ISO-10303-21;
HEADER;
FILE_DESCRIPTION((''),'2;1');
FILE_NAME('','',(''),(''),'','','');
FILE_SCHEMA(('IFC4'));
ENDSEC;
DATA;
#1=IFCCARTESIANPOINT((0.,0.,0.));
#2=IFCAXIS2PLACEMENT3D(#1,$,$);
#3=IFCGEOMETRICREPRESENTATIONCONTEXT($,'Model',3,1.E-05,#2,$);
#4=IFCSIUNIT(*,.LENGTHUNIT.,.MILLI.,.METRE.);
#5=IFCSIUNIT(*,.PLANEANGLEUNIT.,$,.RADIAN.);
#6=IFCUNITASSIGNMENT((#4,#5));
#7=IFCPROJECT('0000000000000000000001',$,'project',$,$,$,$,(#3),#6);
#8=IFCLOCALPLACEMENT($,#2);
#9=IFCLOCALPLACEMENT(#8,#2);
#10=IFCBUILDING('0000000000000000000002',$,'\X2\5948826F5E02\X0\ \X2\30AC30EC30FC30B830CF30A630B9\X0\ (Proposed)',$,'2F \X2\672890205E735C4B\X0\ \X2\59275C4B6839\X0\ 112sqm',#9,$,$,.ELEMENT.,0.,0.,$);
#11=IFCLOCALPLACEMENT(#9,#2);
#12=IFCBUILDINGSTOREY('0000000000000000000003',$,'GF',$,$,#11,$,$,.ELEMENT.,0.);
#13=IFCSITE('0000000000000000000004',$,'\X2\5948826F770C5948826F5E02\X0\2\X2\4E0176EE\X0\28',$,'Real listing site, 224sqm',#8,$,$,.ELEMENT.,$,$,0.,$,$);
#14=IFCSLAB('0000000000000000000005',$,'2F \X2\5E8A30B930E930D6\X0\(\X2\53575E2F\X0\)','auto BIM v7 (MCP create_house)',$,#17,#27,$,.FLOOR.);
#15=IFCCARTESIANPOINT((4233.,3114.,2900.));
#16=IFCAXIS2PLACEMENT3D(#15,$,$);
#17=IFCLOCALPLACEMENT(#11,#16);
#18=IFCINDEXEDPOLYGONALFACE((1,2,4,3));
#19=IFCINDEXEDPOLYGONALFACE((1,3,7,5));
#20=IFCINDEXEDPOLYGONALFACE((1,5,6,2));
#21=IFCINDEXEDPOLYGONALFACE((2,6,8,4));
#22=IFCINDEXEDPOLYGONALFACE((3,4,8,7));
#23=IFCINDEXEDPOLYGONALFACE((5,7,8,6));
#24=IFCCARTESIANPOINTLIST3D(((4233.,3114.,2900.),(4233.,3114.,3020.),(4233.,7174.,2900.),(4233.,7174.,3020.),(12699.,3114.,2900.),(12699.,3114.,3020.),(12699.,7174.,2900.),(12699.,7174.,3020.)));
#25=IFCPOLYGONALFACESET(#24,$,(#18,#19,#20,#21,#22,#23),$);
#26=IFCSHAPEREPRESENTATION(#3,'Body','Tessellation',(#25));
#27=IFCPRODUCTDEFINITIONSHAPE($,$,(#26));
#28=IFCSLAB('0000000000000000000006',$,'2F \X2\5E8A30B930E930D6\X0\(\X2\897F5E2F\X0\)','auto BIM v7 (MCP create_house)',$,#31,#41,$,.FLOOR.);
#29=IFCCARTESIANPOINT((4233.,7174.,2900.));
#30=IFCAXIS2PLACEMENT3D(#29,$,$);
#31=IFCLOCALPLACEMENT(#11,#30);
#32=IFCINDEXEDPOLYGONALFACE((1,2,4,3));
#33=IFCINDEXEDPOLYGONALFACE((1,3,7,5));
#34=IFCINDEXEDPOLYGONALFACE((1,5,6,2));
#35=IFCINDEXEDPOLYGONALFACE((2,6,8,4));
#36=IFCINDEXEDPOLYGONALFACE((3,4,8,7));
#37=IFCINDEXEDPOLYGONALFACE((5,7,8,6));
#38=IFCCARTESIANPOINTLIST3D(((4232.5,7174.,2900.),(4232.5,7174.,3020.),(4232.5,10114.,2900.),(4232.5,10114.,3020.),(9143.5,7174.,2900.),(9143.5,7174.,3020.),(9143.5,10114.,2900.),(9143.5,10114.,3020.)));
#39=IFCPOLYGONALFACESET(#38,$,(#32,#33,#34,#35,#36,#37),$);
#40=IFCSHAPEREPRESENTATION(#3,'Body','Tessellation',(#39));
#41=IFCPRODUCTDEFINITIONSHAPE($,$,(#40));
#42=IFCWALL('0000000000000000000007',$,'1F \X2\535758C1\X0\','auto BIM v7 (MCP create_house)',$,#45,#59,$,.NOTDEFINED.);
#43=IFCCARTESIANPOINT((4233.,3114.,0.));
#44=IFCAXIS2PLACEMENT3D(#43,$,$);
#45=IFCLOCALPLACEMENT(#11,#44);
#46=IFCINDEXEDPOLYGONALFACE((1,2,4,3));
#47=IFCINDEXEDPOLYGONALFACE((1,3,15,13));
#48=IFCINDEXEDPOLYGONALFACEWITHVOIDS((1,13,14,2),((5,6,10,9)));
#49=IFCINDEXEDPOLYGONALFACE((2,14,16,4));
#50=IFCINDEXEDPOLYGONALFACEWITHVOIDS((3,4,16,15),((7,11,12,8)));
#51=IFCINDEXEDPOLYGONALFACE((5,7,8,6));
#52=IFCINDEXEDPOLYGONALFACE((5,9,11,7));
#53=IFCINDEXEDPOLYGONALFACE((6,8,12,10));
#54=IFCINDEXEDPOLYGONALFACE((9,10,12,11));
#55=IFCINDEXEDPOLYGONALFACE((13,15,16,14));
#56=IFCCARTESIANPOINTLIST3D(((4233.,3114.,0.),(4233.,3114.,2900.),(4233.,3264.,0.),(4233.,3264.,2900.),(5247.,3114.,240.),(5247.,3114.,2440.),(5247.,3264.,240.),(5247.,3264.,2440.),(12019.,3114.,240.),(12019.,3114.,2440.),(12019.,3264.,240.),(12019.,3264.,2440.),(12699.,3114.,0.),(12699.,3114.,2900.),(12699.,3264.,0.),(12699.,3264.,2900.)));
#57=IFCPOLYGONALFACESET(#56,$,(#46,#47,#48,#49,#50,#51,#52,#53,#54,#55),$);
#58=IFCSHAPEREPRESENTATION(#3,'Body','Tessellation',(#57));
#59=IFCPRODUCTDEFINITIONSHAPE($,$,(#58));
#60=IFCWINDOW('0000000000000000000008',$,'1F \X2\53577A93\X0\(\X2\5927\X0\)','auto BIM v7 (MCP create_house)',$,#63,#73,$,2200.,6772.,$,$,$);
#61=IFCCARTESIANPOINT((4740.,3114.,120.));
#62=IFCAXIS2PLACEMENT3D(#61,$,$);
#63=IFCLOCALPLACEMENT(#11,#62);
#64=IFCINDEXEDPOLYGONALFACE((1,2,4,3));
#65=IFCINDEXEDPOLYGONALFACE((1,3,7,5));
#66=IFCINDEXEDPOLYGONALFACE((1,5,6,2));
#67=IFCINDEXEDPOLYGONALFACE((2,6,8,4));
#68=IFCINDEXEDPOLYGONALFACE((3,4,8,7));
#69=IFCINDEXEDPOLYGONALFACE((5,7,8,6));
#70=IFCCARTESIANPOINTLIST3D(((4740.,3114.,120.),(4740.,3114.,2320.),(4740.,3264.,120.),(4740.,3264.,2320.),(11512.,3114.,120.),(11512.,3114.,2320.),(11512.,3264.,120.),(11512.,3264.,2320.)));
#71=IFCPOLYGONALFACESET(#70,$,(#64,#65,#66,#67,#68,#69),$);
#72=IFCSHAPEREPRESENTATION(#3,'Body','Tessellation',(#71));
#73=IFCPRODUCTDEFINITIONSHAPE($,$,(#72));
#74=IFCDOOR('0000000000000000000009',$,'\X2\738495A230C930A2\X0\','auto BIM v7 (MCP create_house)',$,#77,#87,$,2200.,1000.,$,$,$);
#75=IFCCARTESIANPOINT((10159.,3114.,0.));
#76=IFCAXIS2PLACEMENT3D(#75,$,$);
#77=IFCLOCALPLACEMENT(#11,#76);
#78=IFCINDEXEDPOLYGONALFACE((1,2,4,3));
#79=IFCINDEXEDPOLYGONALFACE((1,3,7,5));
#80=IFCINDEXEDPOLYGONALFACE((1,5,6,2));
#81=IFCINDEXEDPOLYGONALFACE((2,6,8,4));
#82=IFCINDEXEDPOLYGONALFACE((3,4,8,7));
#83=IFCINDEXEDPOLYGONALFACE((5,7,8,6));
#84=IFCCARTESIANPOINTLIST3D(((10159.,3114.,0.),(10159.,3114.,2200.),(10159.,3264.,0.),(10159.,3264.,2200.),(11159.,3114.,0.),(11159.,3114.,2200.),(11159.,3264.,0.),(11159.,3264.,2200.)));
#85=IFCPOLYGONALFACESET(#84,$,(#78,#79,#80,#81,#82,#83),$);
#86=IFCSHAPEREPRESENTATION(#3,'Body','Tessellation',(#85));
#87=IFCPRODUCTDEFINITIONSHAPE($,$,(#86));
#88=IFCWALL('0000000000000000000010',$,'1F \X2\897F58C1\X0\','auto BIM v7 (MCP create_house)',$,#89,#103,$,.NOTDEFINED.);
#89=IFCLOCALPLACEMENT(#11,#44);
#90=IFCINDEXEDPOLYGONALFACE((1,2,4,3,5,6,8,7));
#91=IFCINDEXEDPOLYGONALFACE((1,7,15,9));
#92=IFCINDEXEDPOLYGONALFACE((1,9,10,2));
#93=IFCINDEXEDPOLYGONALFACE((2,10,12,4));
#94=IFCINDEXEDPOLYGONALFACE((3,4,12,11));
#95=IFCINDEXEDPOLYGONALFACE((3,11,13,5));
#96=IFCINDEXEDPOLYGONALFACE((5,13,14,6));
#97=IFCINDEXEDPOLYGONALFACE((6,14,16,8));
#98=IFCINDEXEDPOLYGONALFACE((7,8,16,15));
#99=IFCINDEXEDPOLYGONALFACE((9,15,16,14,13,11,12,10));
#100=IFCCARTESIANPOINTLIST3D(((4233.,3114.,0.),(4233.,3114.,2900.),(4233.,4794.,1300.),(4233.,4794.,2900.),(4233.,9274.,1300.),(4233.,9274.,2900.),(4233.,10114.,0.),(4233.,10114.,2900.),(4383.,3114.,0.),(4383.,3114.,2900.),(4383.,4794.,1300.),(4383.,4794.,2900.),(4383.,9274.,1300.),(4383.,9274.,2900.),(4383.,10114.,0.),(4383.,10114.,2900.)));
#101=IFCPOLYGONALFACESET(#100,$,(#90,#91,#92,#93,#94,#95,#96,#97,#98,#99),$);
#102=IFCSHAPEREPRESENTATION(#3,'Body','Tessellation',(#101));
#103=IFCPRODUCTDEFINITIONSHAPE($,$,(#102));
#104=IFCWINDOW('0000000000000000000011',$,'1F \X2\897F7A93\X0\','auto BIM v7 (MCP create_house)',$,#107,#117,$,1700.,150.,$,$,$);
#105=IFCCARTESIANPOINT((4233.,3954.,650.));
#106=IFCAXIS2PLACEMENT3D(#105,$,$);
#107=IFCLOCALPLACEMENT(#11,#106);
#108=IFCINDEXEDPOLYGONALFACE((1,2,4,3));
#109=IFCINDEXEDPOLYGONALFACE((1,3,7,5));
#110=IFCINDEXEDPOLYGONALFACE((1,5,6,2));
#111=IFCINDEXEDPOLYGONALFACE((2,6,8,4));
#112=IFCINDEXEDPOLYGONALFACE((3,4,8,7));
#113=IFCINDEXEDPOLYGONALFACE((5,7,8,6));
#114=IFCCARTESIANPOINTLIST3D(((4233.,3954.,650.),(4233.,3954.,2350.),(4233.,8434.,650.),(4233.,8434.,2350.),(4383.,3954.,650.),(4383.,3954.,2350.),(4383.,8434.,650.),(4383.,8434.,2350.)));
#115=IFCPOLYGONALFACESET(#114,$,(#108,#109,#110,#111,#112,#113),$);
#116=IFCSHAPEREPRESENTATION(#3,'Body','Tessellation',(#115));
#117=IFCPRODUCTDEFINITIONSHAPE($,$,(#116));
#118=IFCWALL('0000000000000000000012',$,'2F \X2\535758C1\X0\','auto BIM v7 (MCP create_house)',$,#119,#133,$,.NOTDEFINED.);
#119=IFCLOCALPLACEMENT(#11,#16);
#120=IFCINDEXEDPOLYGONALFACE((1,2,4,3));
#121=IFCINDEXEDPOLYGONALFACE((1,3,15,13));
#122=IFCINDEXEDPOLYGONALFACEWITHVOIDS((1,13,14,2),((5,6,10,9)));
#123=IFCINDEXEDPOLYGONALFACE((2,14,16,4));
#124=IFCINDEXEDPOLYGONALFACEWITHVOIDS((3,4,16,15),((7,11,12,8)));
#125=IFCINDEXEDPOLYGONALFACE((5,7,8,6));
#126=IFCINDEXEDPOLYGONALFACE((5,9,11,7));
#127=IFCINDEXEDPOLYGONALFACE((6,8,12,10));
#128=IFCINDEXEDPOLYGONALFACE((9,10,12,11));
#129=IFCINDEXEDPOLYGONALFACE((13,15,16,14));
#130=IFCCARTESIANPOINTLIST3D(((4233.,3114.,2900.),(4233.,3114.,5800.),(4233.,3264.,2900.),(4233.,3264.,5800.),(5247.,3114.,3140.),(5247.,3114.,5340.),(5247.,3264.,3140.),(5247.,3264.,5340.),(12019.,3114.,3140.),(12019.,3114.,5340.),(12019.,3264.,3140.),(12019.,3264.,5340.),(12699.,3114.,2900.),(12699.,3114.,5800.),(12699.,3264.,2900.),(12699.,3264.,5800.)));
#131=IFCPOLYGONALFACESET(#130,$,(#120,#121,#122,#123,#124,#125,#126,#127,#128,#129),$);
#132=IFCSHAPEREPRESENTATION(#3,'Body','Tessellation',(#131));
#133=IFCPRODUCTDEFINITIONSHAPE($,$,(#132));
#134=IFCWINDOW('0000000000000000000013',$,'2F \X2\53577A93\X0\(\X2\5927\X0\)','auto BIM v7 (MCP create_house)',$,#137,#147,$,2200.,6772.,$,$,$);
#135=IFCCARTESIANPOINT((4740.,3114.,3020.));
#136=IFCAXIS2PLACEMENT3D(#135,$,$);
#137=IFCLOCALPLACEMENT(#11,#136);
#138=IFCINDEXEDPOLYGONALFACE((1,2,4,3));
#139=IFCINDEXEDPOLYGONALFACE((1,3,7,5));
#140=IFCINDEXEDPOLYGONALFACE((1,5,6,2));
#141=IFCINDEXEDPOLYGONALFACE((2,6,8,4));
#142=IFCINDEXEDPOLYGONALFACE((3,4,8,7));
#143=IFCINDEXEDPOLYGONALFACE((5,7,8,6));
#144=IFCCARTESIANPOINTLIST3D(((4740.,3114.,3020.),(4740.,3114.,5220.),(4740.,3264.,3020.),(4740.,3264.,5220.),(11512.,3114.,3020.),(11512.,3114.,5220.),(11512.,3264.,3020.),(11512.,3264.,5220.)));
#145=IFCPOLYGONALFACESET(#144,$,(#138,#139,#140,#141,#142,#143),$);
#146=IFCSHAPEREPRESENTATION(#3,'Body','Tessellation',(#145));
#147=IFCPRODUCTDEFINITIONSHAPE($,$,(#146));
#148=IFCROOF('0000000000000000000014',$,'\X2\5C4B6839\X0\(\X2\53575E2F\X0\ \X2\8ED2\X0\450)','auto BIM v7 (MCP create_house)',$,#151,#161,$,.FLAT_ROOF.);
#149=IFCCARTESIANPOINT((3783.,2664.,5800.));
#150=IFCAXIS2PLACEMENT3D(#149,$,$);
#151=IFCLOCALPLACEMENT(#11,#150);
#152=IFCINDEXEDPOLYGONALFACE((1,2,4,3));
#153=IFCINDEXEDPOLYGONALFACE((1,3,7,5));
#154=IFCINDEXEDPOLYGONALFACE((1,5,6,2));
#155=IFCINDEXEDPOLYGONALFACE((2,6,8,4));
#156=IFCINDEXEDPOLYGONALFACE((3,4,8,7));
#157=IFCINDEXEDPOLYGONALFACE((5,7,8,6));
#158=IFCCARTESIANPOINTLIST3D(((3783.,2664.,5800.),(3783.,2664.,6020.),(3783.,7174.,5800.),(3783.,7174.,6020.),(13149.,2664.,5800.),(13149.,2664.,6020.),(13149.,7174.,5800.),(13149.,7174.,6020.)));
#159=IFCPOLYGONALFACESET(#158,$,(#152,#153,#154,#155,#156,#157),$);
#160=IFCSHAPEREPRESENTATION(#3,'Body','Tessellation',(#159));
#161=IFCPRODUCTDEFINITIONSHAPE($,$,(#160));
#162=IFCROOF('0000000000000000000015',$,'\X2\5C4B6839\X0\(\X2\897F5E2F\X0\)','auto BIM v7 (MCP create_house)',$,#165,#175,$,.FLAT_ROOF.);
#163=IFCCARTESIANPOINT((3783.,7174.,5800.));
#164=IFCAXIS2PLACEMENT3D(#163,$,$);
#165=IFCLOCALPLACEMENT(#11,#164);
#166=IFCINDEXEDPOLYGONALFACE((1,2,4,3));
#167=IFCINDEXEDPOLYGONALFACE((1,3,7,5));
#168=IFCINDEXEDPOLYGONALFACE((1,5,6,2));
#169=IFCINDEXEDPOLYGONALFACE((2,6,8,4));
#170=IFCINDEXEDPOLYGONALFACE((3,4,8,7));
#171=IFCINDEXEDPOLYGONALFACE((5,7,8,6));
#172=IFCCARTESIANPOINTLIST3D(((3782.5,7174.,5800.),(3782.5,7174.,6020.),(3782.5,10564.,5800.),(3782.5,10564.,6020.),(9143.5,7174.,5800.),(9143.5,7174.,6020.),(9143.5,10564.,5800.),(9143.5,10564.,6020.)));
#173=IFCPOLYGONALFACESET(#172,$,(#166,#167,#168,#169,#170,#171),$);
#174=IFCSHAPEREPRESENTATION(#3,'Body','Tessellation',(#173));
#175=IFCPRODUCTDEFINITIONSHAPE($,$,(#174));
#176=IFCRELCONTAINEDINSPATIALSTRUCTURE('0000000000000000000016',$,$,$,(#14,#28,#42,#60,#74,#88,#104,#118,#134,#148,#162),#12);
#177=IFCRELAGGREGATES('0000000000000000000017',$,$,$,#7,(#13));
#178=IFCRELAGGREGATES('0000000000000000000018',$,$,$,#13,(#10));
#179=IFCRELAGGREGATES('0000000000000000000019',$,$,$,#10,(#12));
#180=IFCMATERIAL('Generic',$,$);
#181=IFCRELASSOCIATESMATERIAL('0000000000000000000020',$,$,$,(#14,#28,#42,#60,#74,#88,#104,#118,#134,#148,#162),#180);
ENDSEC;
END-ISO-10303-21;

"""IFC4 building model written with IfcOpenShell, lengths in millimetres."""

from ifc_helpers import new_model, si_unit, frame, frame_2d, origin, place, context, project, spatial, rectangle, extrude, material, element, fill, save


model = new_model("IFC4")

# Units and contexts
model_context = context("Model", 3, precision=1e-05, world=origin())
ifc_project = project(units=[si_unit("LENGTHUNIT", "METRE", prefix="MILLI"), si_unit("PLANEANGLEUNIT", "RADIAN")], contexts=[model_context])

# Site, building, storey
site_placement = place(None, origin())
site = spatial("IfcSite", under=ifc_project, at=site_placement, Name="奈良県奈良市2丁目28", ObjectType="Real listing site, 224sqm", CompositionType="ELEMENT", RefElevation=0.0)
building_placement = place(site_placement, origin())
building = spatial("IfcBuilding", under=site, at=building_placement, Name="奈良市 ガレージハウス (Proposed)", ObjectType="2F 木造平屋 大屋根 112sqm", CompositionType="ELEMENT", ElevationOfRefHeight=0.0, ElevationOfTerrain=0.0)
storey_placement = place(building_placement, origin())
storey = spatial("IfcBuildingStorey", under=building, at=storey_placement, Name="GF", CompositionType="ELEMENT", Elevation=0.0)

# Slabs
ifc_material = material(Name="Generic")
slab_1_placement = place(storey_placement, frame((4233.0, 3114.0, 2900.0)))
element("IfcSlab", 1, at=slab_1_placement, inside=storey, material=ifc_material, Name="2F 床スラブ(南帯)", Description="auto BIM v7 (MCP create_house)", PredefinedType="FLOOR", context=model_context, shape_type="SweptSolid", body=[
    extrude(rectangle(XDim=8466.0, YDim=4060.0, at=frame_2d((4233.0, 2030.0))), frame((4233.0, 3114.0, 2900.0)), (0.0, 0.0, 1.0), 120.0),
])
slab_2_placement = place(storey_placement, frame((4233.0, 7174.0, 2900.0)))
element("IfcSlab", 2, at=slab_2_placement, inside=storey, material=ifc_material, Name="2F 床スラブ(西帯)", Description="auto BIM v7 (MCP create_house)", PredefinedType="FLOOR", context=model_context, shape_type="SweptSolid", body=[
    extrude(rectangle(XDim=4911.0, YDim=2940.0, at=frame_2d((2455.0, 1470.0))), frame((4233.0, 7174.0, 2900.0)), (0.0, 0.0, 1.0), 120.0),
])

# Wall, openings, window, door
wall_1_placement = place(storey_placement, frame((4233.0, 3114.0, 0.0)))
wall_1 = element("IfcWall", 3, at=wall_1_placement, inside=storey, material=ifc_material, Name="1F 南壁", Description="auto BIM v7 (MCP create_house)", PredefinedType="NOTDEFINED", context=model_context, shape_type="SweptSolid", body=[
    extrude(rectangle(XDim=8466.0, YDim=150.0, at=frame_2d((4233.0, 75.0))), frame((4233.0, 3114.0, 0.0)), (0.0, 0.0, 1.0), 2900.0),
])
opening_1_placement = place(storey_placement, frame((4740.0, 3114.0, 120.0)))
opening_1 = element("IfcOpeningElement", 4, at=opening_1_placement, cuts=wall_1, PredefinedType="NOTDEFINED", context=model_context, shape_type="SweptSolid", body=[
    extrude(rectangle(XDim=6772.0, YDim=150.0, at=frame_2d((3386.0, 75.0))), frame((4740.0, 3114.0, 120.0)), (0.0, 0.0, 1.0), 2200.0),
])
opening_2_placement = place(storey_placement, frame((10159.0, 3114.0, 0.0)))
opening_2 = element("IfcOpeningElement", 5, at=opening_2_placement, cuts=wall_1, PredefinedType="NOTDEFINED", context=model_context, shape_type="SweptSolid", body=[
    extrude(rectangle(XDim=1000.0, YDim=150.0, at=frame_2d((500.0, 75.0))), frame((10159.0, 3114.0, 0.0)), (0.0, 0.0, 1.0), 2200.0),
])
window_1_placement = place(storey_placement, frame((4740.0, 3114.0, 120.0)))
window_1 = element("IfcWindow", 6, at=window_1_placement, inside=storey, material=ifc_material, Name="1F 南窓(大)", Description="auto BIM v7 (MCP create_house)", OverallHeight=2200.0, OverallWidth=6772.0, context=model_context, shape_type="SweptSolid", body=[
    extrude(rectangle(XDim=6772.0, YDim=150.0, at=frame_2d((3386.0, 75.0))), frame((4740.0, 3114.0, 120.0)), (0.0, 0.0, 1.0), 2200.0),
])
fill(opening_1, window_1)
door_placement = place(storey_placement, frame((10159.0, 3114.0, 0.0)))
door = element("IfcDoor", 7, at=door_placement, inside=storey, material=ifc_material, Name="玄関ドア", Description="auto BIM v7 (MCP create_house)", OverallHeight=2200.0, OverallWidth=1000.0, context=model_context, shape_type="SweptSolid", body=[
    extrude(rectangle(XDim=1000.0, YDim=150.0, at=frame_2d((500.0, 75.0))), frame((10159.0, 3114.0, 0.0)), (0.0, 0.0, 1.0), 2200.0),
])
fill(opening_2, door)

# Wall, opening, window
wall_2_placement = place(storey_placement, frame((4233.0, 3114.0, 0.0)))
wall_2 = element("IfcWall", 8, at=wall_2_placement, inside=storey, material=ifc_material, Name="1F 西壁", Description="auto BIM v7 (MCP create_house)", PredefinedType="NOTDEFINED", context=model_context, shape_type="SweptSolid", body=[
    extrude(rectangle(XDim=150.0, YDim=7000.0, at=frame_2d((75.0, 3500.0))), frame((4233.0, 3114.0, 0.0)), (0.0, 0.0, 1.0), 2900.0),
])
opening_3_placement = place(storey_placement, frame((4233.0, 3954.0, 650.0)))
opening_3 = element("IfcOpeningElement", 9, at=opening_3_placement, cuts=wall_2, PredefinedType="NOTDEFINED", context=model_context, shape_type="SweptSolid", body=[
    extrude(rectangle(XDim=150.0, YDim=4480.0, at=frame_2d((75.0, 2240.0))), frame((4233.0, 3954.0, 650.0)), (0.0, 0.0, 1.0), 1700.0),
])
window_2_placement = place(storey_placement, frame((4233.0, 3954.0, 650.0)))
window_2 = element("IfcWindow", 10, at=window_2_placement, inside=storey, material=ifc_material, Name="1F 西窓", Description="auto BIM v7 (MCP create_house)", OverallHeight=1700.0, OverallWidth=150.0, context=model_context, shape_type="SweptSolid", body=[
    extrude(rectangle(XDim=150.0, YDim=4480.0, at=frame_2d((75.0, 2240.0))), frame((4233.0, 3954.0, 650.0)), (0.0, 0.0, 1.0), 1700.0),
])
fill(opening_3, window_2)

# Wall, opening, window
wall_3_placement = place(storey_placement, frame((4233.0, 3114.0, 2900.0)))
wall_3 = element("IfcWall", 11, at=wall_3_placement, inside=storey, material=ifc_material, Name="2F 南壁", Description="auto BIM v7 (MCP create_house)", PredefinedType="NOTDEFINED", context=model_context, shape_type="SweptSolid", body=[
    extrude(rectangle(XDim=8466.0, YDim=150.0, at=frame_2d((4233.0, 75.0))), frame((4233.0, 3114.0, 2900.0)), (0.0, 0.0, 1.0), 2900.0),
])
opening_4_placement = place(storey_placement, frame((4740.0, 3114.0, 3020.0)))
opening_4 = element("IfcOpeningElement", 12, at=opening_4_placement, cuts=wall_3, PredefinedType="NOTDEFINED", context=model_context, shape_type="SweptSolid", body=[
    extrude(rectangle(XDim=6772.0, YDim=150.0, at=frame_2d((3386.0, 75.0))), frame((4740.0, 3114.0, 3020.0)), (0.0, 0.0, 1.0), 2200.0),
])
window_3_placement = place(storey_placement, frame((4740.0, 3114.0, 3020.0)))
window_3 = element("IfcWindow", 13, at=window_3_placement, inside=storey, material=ifc_material, Name="2F 南窓(大)", Description="auto BIM v7 (MCP create_house)", OverallHeight=2200.0, OverallWidth=6772.0, context=model_context, shape_type="SweptSolid", body=[
    extrude(rectangle(XDim=6772.0, YDim=150.0, at=frame_2d((3386.0, 75.0))), frame((4740.0, 3114.0, 3020.0)), (0.0, 0.0, 1.0), 2200.0),
])
fill(opening_4, window_3)

# Roofs
roof_1_placement = place(storey_placement, frame((3783.0, 2664.0, 5800.0)))
element("IfcRoof", 14, at=roof_1_placement, inside=storey, material=ifc_material, Name="屋根(南帯 軒450)", Description="auto BIM v7 (MCP create_house)", PredefinedType="FLAT_ROOF", context=model_context, shape_type="SweptSolid", body=[
    extrude(rectangle(XDim=9366.0, YDim=4510.0, at=frame_2d((4683.0, 2255.0))), frame((3783.0, 2664.0, 5800.0)), (0.0, 0.0, 1.0), 220.0),
])
roof_2_placement = place(storey_placement, frame((3783.0, 7174.0, 5800.0)))
element("IfcRoof", 15, at=roof_2_placement, inside=storey, material=ifc_material, Name="屋根(西帯)", Description="auto BIM v7 (MCP create_house)", PredefinedType="FLAT_ROOF", context=model_context, shape_type="SweptSolid", body=[
    extrude(rectangle(XDim=5361.0, YDim=3390.0, at=frame_2d((2680.0, 1695.0))), frame((3783.0, 7174.0, 5800.0)), (0.0, 0.0, 1.0), 220.0),
])

save(model, "model.ifc")
